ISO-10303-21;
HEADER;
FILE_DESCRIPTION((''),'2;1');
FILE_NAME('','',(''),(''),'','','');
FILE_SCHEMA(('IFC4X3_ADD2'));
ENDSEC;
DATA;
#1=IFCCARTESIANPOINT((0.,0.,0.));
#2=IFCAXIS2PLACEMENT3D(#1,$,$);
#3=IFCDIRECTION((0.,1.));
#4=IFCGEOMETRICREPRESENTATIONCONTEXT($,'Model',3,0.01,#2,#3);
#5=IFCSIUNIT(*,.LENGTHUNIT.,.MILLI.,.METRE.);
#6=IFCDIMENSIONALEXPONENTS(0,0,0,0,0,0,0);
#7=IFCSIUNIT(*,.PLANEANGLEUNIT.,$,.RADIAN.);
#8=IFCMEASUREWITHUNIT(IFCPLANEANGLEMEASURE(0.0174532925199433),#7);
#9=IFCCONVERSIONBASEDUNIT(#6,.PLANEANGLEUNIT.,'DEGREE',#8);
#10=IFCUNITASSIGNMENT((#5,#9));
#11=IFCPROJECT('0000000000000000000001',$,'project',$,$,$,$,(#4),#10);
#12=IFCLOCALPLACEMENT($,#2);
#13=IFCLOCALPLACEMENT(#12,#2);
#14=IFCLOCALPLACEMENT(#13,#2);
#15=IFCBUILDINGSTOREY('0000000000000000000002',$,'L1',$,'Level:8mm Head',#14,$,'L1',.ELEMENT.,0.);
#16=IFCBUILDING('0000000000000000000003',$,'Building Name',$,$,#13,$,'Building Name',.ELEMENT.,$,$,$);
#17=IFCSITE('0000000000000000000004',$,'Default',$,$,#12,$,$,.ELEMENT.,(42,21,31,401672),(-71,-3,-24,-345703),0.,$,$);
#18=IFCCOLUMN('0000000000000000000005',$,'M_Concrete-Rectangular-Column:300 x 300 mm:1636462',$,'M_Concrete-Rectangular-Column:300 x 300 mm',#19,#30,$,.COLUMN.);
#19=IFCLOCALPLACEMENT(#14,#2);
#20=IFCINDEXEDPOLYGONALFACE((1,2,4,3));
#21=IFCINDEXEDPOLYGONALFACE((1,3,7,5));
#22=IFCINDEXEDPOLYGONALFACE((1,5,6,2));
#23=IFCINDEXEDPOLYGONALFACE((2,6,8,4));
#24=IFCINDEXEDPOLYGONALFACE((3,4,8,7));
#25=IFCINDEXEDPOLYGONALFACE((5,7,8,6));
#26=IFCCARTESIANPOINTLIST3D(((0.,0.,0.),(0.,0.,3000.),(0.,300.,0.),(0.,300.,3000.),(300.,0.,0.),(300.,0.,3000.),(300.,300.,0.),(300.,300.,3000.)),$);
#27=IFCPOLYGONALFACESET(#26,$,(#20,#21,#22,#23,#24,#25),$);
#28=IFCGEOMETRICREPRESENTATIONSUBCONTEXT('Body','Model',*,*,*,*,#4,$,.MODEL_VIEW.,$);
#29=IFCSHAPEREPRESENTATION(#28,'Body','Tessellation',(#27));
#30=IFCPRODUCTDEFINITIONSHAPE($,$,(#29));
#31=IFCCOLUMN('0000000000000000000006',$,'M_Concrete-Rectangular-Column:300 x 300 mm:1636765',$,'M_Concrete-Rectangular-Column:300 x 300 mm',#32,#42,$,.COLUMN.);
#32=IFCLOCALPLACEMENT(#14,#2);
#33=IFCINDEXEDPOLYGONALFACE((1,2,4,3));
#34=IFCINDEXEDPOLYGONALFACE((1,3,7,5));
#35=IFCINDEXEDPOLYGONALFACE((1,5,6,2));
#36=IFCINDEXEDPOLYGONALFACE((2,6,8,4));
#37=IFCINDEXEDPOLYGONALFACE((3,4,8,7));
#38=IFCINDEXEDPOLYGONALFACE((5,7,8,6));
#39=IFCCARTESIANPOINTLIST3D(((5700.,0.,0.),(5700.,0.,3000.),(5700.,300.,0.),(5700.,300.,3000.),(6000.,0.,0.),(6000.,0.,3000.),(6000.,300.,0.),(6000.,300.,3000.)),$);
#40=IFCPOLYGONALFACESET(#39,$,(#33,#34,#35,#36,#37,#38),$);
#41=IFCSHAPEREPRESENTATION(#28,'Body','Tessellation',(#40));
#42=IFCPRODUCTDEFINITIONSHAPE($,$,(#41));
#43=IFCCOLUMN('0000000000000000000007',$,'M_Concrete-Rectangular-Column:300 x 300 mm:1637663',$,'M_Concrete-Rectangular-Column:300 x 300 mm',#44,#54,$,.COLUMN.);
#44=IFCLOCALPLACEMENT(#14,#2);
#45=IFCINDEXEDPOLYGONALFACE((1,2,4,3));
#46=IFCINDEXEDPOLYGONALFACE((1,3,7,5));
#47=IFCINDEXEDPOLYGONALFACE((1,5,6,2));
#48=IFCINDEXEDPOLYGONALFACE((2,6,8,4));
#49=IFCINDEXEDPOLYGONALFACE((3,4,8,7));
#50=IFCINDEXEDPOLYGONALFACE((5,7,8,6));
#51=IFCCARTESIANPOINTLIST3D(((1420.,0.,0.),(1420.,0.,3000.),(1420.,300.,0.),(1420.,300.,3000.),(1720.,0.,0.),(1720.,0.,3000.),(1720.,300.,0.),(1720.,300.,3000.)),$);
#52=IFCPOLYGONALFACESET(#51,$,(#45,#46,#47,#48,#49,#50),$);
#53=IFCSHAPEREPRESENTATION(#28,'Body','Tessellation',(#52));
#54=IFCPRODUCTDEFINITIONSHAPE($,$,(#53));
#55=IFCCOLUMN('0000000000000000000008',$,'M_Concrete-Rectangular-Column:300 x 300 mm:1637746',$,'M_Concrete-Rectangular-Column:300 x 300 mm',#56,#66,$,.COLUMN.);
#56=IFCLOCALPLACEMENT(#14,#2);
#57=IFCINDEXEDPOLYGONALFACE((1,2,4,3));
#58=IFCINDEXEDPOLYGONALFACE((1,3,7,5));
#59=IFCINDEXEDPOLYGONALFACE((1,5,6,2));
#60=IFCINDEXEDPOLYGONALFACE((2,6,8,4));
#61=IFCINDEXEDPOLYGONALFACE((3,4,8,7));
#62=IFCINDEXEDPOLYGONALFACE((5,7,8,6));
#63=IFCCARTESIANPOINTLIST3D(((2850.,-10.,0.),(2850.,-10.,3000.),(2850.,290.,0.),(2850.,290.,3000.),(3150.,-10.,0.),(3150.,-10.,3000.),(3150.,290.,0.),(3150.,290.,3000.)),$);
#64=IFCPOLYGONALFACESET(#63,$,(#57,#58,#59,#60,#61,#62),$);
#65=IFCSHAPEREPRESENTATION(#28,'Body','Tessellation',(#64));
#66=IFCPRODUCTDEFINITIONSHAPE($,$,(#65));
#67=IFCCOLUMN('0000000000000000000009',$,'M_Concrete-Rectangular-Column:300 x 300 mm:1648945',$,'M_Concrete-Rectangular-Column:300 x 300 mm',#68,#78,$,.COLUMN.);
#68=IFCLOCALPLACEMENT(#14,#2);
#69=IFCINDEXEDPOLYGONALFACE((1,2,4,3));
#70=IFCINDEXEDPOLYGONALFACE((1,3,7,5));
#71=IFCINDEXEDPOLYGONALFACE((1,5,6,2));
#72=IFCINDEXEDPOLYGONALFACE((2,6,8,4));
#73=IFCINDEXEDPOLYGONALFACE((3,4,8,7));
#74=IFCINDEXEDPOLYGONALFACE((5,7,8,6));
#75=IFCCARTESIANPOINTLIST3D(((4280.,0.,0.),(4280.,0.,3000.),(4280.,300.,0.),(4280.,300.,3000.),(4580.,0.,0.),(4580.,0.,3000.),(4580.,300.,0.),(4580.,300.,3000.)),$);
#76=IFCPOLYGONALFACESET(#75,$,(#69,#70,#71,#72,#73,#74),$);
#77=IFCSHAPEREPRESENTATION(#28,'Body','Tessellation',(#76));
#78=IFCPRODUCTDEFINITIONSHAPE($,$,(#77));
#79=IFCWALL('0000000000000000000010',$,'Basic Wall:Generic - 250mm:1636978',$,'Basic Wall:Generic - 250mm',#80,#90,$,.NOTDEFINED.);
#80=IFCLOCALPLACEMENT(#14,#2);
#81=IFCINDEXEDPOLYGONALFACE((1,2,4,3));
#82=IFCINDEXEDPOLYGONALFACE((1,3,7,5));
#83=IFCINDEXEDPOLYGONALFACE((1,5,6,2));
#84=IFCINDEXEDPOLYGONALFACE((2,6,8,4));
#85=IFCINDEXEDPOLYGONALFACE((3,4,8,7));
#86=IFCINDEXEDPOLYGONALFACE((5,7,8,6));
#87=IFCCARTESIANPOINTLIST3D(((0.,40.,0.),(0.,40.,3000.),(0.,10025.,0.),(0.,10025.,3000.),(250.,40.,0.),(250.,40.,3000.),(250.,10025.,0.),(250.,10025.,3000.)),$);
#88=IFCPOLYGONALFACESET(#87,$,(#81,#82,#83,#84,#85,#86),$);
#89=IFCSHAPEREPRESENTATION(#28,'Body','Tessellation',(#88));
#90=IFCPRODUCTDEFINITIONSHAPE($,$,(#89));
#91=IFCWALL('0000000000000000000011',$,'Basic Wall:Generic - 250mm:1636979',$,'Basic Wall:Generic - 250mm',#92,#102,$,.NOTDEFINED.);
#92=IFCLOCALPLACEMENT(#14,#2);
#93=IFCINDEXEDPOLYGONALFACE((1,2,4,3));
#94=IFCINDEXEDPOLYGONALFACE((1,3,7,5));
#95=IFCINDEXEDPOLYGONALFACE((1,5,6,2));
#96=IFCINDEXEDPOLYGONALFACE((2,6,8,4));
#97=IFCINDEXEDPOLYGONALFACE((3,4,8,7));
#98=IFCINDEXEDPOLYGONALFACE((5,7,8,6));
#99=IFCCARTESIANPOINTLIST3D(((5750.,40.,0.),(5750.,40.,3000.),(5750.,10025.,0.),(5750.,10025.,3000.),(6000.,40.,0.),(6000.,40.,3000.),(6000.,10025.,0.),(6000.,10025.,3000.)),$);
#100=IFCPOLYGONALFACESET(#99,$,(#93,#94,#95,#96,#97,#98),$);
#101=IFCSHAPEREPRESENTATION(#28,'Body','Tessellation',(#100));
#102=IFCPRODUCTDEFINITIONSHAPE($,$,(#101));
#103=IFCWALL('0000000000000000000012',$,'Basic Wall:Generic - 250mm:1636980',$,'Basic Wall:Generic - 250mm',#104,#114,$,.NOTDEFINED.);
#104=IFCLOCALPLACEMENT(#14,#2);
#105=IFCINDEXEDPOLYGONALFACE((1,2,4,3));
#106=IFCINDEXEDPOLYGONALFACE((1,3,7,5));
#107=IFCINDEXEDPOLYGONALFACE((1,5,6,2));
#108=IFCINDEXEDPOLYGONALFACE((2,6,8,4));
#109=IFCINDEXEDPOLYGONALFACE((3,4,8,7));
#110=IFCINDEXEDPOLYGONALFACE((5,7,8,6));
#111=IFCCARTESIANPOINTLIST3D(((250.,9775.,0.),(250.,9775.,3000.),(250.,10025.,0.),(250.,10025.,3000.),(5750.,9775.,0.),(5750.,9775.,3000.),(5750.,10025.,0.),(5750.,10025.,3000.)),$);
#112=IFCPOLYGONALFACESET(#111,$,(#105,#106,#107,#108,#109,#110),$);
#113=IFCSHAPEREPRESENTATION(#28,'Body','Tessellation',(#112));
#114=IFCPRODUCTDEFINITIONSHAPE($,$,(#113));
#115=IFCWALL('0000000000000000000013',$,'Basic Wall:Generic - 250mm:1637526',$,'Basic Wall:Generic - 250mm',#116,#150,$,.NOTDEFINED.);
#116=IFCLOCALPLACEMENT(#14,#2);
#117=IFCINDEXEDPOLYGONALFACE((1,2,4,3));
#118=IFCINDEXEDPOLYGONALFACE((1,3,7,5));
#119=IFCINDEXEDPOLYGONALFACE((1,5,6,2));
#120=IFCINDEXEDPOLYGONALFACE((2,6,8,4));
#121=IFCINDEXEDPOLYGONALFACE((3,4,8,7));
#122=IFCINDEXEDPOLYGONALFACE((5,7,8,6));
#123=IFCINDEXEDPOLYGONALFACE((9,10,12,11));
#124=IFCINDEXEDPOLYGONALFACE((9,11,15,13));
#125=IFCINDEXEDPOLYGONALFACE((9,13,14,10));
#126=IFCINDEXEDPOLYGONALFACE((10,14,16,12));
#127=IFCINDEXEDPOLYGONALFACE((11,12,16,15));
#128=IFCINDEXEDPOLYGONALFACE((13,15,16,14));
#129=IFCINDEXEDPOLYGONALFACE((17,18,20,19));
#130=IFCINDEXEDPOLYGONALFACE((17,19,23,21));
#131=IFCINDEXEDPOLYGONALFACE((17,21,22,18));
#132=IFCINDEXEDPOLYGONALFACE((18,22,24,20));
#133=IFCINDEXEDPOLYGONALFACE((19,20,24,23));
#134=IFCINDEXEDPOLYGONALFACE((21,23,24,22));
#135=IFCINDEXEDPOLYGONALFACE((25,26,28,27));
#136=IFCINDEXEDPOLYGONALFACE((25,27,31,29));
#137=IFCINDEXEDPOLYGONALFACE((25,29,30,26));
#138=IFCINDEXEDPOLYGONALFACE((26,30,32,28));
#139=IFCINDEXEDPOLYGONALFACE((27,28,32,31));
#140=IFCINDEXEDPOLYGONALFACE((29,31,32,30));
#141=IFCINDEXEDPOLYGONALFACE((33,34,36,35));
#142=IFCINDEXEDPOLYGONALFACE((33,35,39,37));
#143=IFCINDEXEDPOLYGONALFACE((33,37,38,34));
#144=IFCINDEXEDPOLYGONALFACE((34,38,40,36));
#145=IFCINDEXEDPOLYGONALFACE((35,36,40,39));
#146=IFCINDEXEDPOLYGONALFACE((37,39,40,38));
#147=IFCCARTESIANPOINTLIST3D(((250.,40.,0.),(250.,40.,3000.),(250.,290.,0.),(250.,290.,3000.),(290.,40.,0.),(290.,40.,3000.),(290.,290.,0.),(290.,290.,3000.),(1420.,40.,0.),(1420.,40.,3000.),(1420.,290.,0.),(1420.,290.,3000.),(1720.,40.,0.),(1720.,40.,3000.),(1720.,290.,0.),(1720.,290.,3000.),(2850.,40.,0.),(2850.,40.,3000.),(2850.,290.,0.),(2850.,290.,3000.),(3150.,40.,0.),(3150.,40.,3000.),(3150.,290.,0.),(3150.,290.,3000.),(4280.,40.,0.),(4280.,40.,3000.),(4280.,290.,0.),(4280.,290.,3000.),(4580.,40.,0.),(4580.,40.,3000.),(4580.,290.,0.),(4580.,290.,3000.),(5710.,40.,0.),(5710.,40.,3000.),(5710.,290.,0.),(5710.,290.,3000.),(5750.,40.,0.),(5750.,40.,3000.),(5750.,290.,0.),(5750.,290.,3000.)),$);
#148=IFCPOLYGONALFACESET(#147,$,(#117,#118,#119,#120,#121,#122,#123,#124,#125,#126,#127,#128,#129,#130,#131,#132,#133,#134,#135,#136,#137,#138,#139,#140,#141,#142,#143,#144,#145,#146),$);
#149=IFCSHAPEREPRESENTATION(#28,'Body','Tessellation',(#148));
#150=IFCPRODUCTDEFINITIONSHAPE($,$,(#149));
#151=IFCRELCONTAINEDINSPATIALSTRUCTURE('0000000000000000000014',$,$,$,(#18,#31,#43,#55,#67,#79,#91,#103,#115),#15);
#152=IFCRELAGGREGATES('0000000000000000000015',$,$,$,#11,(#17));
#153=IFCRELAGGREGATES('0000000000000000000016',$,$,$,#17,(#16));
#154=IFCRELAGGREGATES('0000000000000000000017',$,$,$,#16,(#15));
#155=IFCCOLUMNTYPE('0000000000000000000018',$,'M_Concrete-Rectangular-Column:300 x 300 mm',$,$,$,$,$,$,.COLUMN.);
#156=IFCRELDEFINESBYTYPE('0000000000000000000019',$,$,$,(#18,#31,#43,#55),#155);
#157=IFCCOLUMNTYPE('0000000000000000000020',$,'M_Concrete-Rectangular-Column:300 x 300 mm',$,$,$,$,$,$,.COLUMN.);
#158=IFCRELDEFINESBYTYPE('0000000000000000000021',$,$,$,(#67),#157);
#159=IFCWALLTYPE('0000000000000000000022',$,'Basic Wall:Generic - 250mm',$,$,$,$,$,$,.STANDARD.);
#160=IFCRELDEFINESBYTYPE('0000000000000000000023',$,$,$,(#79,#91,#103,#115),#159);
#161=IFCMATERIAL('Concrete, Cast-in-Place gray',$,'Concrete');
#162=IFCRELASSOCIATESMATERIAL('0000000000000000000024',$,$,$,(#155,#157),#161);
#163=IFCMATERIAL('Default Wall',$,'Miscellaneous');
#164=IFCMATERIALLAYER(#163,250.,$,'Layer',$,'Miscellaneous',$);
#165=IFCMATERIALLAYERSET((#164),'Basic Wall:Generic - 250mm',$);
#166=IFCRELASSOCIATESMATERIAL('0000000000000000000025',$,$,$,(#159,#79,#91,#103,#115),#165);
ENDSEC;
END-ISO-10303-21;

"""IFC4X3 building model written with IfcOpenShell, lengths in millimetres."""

from ifc_helpers import new_model, entity, si_unit, converted_unit, direction, frame, frame_2d, origin, origin_2d_with_axis, place, context, subcontext, project, spatial, rectangle, extrude, source, transform, mapped, material, layer, layer_set, material_profile, profile_set, type_object, type_shapes, element, save


model = new_model("IFC4X3")

# Units and contexts
model_context = context("Model", 3, precision=0.01, world=origin(), true_north=direction((0.0, 1.0)))
body_context = subcontext(model_context, "Body", "Model", "MODEL_VIEW")
ifc_project = project(units=[si_unit("LENGTHUNIT", "METRE", prefix="MILLI"), converted_unit("PLANEANGLEUNIT", "DEGREE", entity("IfcPlaneAngleMeasure", 0.0174532925199433), si_unit("PLANEANGLEUNIT", "RADIAN"), dimensions=[0, 0, 0, 0, 0, 0, 0])], contexts=[model_context])

# Site, building, storey
site_placement = place(None, origin())
site = spatial("IfcSite", under=ifc_project, at=site_placement, Name="Default", CompositionType="ELEMENT", RefLatitude=(42, 21, 31, 401672), RefLongitude=(-71, -3, -24, -345703), RefElevation=0.0)
building_placement = place(site_placement, origin())
building = spatial("IfcBuilding", under=site, at=building_placement, Name="Building Name", LongName="Building Name", CompositionType="ELEMENT")
storey_placement = place(building_placement, origin())
storey = spatial("IfcBuildingStorey", under=building, at=storey_placement, Name="L1", ObjectType="Level:8mm Head", LongName="L1", CompositionType="ELEMENT", Elevation=0.0)

# Columns
ifc_material_1 = material(Name="Concrete, Cast-in-Place gray", Category="Concrete")
ifc_material_profile = material_profile(ifc_material_1, rectangle(XDim=300.0, YDim=300.0, at=origin_2d_with_axis()), Name="300 x 300 mm")
ifc_profile_set = profile_set([ifc_material_profile], Name="300 x 300 mm")
column_type_1 = type_object("IfcColumnType", Name="M_Concrete-Rectangular-Column:300 x 300 mm", PredefinedType="COLUMN", material=ifc_profile_set)
shared_shape_1 = source(origin(), body_context, "Body", "SweptSolid", [
    extrude(rectangle(XDim=300.0, YDim=300.0, at=origin_2d_with_axis()), frame((0.0, 0.0, 0.0), z_axis=(0.0, 0.0, 1.0), x_axis=(-1.0, 0.0, 0.0)), (0.0, 0.0, 1.0), 3000.0),
])
type_shapes(column_type_1, [shared_shape_1])
for number, where, name in (
    (1, (150.0, 150.0, 0.0), "M_Concrete-Rectangular-Column:300 x 300 mm:1636462"),
    (2, (5850.0, 150.0, 0.0), "M_Concrete-Rectangular-Column:300 x 300 mm:1636765"),
    (3, (1570.0, 150.0, 0.0), "M_Concrete-Rectangular-Column:300 x 300 mm:1637663"),
    (4, (3000.0, 140.0, 0.0), "M_Concrete-Rectangular-Column:300 x 300 mm:1637746"),
):
    element("IfcColumn", number, at=place(storey_placement, frame(where)), inside=storey, type_object=column_type_1, Name=name, ObjectType="M_Concrete-Rectangular-Column:300 x 300 mm", PredefinedType="COLUMN", context=body_context, shape_type="MappedRepresentation", body=[
        mapped(shared_shape_1, transform((0.0, 0.0, 0.0), scale=1.0)),
    ])
column_type_2 = type_object("IfcColumnType", Name="M_Concrete-Rectangular-Column:300 x 300 mm", PredefinedType="COLUMN", material=ifc_profile_set)
shared_shape_2 = source(origin(), body_context, "Body", "SweptSolid", [
    extrude(rectangle(XDim=300.0, YDim=300.0, at=origin_2d_with_axis()), frame((0.0, 0.0, 0.0), z_axis=(0.0, 0.0, 1.0), x_axis=(0.0, 1.0, 0.0)), (0.0, 0.0, 1.0), 3000.0),
])
type_shapes(column_type_2, [shared_shape_2])
column_placement = place(storey_placement, frame((4430.0, 150.0, 0.0), z_axis=(0.0, 0.0, 1.0), x_axis=(-1.0, 0.0, 0.0)))
element("IfcColumn", 5, at=column_placement, inside=storey, type_object=column_type_2, Name="M_Concrete-Rectangular-Column:300 x 300 mm:1648945", ObjectType="M_Concrete-Rectangular-Column:300 x 300 mm", PredefinedType="COLUMN", context=body_context, shape_type="MappedRepresentation", body=[
    mapped(shared_shape_2, transform((0.0, 0.0, 0.0), scale=1.0)),
])

# Walls
ifc_material_2 = material(Name="Default Wall", Category="Miscellaneous")
ifc_layer = layer(ifc_material_2, 250.0, Name="Layer", Category="Miscellaneous")
ifc_layer_set = layer_set([ifc_layer], Name="Basic Wall:Generic - 250mm")
wall_type = type_object("IfcWallType", Name="Basic Wall:Generic - 250mm", PredefinedType="STANDARD", material=ifc_layer_set)
wall_1_placement = place(storey_placement, frame((125.0, 10025.0, 0.0), z_axis=(0.0, 0.0, 1.0), x_axis=(0.0, -1.0, 0.0)))
element("IfcWall", 6, at=wall_1_placement, inside=storey, type_object=wall_type, material=ifc_layer_set, Name="Basic Wall:Generic - 250mm:1636978", ObjectType="Basic Wall:Generic - 250mm", PredefinedType="NOTDEFINED", context=body_context, shape_type="SweptSolid", body=[
    extrude(rectangle(XDim=9985.0, YDim=250.0, at=frame_2d((4992.5, 0.0), x_axis=(-1.0, 0.0))), origin(), (0.0, 0.0, 1.0), 3000.0),
])
wall_2_placement = place(storey_placement, frame((5875.0, 40.0, 0.0), z_axis=(0.0, 0.0, 1.0), x_axis=(0.0, 1.0, 0.0)))
element("IfcWall", 7, at=wall_2_placement, inside=storey, type_object=wall_type, material=ifc_layer_set, Name="Basic Wall:Generic - 250mm:1636979", ObjectType="Basic Wall:Generic - 250mm", PredefinedType="NOTDEFINED", context=body_context, shape_type="SweptSolid", body=[
    extrude(rectangle(XDim=9985.0, YDim=250.0, at=frame_2d((4992.5, 0.0), x_axis=(-1.0, 0.0))), origin(), (0.0, 0.0, 1.0), 3000.0),
])
wall_3_placement = place(storey_placement, frame((5750.0, 9900.0, 0.0), z_axis=(0.0, 0.0, 1.0), x_axis=(-1.0, 0.0, 0.0)))
element("IfcWall", 8, at=wall_3_placement, inside=storey, type_object=wall_type, material=ifc_layer_set, Name="Basic Wall:Generic - 250mm:1636980", ObjectType="Basic Wall:Generic - 250mm", PredefinedType="NOTDEFINED", context=body_context, shape_type="SweptSolid", body=[
    extrude(rectangle(XDim=5500.0, YDim=250.0, at=frame_2d((2750.0, 0.0), x_axis=(-1.0, 0.0))), origin(), (0.0, 0.0, 1.0), 3000.0),
])

# Wall, openings
wall_4_placement = place(storey_placement, frame((250.0, 165.0, 0.0)))
wall_4 = element("IfcWall", 9, at=wall_4_placement, inside=storey, type_object=wall_type, material=ifc_layer_set, Name="Basic Wall:Generic - 250mm:1637526", ObjectType="Basic Wall:Generic - 250mm", PredefinedType="NOTDEFINED", context=body_context, shape_type="SweptSolid", body=[
    extrude(rectangle(XDim=5500.0, YDim=250.0, at=frame_2d((2750.0, 0.0), x_axis=(-1.0, 0.0))), origin(), (0.0, 0.0, 1.0), 3000.0),
])
opening_1_placement = place(wall_4_placement, frame((40.0, -125.0, 0.0)))
element("IfcOpeningElement", 10, at=opening_1_placement, cuts=wall_4, PredefinedType="OPENING", context=body_context, shape_type="SweptSolid", body=[
    extrude(rectangle(XDim=3000.0, YDim=1130.0, at=frame_2d((1500.0, 565.0), x_axis=(-1.0, 0.0))), frame((0.0, 0.0, 0.0), z_axis=(0.0, 1.0, 0.0), x_axis=(0.0, 0.0, 1.0)), (0.0, 0.0, 1.0), 250.0),
])
opening_2_placement = place(wall_4_placement, frame((1470.0, -125.0, 0.0)))
element("IfcOpeningElement", 11, at=opening_2_placement, cuts=wall_4, PredefinedType="OPENING", context=body_context, shape_type="SweptSolid", body=[
    extrude(rectangle(XDim=3000.0, YDim=1130.0, at=frame_2d((1500.0, 565.0), x_axis=(-1.0, 0.0))), frame((0.0, 0.0, 0.0), z_axis=(0.0, 1.0, 0.0), x_axis=(0.0, 0.0, 1.0)), (0.0, 0.0, 1.0), 250.0),
])
opening_3_placement = place(wall_4_placement, frame((4330.0, -125.0, 0.0)))
element("IfcOpeningElement", 12, at=opening_3_placement, cuts=wall_4, PredefinedType="OPENING", context=body_context, shape_type="SweptSolid", body=[
    extrude(rectangle(XDim=3000.0, YDim=1130.0, at=frame_2d((1500.0, 565.0), x_axis=(-1.0, 0.0))), frame((0.0, 0.0, 0.0), z_axis=(0.0, 1.0, 0.0), x_axis=(0.0, 0.0, 1.0)), (0.0, 0.0, 1.0), 250.0),
])
opening_4_placement = place(wall_4_placement, frame((2900.0, -125.0, 0.0)))
element("IfcOpeningElement", 13, at=opening_4_placement, cuts=wall_4, PredefinedType="OPENING", context=body_context, shape_type="SweptSolid", body=[
    extrude(rectangle(XDim=3000.0, YDim=1130.0, at=frame_2d((1500.0, 565.0), x_axis=(-1.0, 0.0))), frame((0.0, 0.0, 0.0), z_axis=(0.0, 1.0, 0.0), x_axis=(0.0, 0.0, 1.0)), (0.0, 0.0, 1.0), 250.0),
])

save(model, "model.ifc")
